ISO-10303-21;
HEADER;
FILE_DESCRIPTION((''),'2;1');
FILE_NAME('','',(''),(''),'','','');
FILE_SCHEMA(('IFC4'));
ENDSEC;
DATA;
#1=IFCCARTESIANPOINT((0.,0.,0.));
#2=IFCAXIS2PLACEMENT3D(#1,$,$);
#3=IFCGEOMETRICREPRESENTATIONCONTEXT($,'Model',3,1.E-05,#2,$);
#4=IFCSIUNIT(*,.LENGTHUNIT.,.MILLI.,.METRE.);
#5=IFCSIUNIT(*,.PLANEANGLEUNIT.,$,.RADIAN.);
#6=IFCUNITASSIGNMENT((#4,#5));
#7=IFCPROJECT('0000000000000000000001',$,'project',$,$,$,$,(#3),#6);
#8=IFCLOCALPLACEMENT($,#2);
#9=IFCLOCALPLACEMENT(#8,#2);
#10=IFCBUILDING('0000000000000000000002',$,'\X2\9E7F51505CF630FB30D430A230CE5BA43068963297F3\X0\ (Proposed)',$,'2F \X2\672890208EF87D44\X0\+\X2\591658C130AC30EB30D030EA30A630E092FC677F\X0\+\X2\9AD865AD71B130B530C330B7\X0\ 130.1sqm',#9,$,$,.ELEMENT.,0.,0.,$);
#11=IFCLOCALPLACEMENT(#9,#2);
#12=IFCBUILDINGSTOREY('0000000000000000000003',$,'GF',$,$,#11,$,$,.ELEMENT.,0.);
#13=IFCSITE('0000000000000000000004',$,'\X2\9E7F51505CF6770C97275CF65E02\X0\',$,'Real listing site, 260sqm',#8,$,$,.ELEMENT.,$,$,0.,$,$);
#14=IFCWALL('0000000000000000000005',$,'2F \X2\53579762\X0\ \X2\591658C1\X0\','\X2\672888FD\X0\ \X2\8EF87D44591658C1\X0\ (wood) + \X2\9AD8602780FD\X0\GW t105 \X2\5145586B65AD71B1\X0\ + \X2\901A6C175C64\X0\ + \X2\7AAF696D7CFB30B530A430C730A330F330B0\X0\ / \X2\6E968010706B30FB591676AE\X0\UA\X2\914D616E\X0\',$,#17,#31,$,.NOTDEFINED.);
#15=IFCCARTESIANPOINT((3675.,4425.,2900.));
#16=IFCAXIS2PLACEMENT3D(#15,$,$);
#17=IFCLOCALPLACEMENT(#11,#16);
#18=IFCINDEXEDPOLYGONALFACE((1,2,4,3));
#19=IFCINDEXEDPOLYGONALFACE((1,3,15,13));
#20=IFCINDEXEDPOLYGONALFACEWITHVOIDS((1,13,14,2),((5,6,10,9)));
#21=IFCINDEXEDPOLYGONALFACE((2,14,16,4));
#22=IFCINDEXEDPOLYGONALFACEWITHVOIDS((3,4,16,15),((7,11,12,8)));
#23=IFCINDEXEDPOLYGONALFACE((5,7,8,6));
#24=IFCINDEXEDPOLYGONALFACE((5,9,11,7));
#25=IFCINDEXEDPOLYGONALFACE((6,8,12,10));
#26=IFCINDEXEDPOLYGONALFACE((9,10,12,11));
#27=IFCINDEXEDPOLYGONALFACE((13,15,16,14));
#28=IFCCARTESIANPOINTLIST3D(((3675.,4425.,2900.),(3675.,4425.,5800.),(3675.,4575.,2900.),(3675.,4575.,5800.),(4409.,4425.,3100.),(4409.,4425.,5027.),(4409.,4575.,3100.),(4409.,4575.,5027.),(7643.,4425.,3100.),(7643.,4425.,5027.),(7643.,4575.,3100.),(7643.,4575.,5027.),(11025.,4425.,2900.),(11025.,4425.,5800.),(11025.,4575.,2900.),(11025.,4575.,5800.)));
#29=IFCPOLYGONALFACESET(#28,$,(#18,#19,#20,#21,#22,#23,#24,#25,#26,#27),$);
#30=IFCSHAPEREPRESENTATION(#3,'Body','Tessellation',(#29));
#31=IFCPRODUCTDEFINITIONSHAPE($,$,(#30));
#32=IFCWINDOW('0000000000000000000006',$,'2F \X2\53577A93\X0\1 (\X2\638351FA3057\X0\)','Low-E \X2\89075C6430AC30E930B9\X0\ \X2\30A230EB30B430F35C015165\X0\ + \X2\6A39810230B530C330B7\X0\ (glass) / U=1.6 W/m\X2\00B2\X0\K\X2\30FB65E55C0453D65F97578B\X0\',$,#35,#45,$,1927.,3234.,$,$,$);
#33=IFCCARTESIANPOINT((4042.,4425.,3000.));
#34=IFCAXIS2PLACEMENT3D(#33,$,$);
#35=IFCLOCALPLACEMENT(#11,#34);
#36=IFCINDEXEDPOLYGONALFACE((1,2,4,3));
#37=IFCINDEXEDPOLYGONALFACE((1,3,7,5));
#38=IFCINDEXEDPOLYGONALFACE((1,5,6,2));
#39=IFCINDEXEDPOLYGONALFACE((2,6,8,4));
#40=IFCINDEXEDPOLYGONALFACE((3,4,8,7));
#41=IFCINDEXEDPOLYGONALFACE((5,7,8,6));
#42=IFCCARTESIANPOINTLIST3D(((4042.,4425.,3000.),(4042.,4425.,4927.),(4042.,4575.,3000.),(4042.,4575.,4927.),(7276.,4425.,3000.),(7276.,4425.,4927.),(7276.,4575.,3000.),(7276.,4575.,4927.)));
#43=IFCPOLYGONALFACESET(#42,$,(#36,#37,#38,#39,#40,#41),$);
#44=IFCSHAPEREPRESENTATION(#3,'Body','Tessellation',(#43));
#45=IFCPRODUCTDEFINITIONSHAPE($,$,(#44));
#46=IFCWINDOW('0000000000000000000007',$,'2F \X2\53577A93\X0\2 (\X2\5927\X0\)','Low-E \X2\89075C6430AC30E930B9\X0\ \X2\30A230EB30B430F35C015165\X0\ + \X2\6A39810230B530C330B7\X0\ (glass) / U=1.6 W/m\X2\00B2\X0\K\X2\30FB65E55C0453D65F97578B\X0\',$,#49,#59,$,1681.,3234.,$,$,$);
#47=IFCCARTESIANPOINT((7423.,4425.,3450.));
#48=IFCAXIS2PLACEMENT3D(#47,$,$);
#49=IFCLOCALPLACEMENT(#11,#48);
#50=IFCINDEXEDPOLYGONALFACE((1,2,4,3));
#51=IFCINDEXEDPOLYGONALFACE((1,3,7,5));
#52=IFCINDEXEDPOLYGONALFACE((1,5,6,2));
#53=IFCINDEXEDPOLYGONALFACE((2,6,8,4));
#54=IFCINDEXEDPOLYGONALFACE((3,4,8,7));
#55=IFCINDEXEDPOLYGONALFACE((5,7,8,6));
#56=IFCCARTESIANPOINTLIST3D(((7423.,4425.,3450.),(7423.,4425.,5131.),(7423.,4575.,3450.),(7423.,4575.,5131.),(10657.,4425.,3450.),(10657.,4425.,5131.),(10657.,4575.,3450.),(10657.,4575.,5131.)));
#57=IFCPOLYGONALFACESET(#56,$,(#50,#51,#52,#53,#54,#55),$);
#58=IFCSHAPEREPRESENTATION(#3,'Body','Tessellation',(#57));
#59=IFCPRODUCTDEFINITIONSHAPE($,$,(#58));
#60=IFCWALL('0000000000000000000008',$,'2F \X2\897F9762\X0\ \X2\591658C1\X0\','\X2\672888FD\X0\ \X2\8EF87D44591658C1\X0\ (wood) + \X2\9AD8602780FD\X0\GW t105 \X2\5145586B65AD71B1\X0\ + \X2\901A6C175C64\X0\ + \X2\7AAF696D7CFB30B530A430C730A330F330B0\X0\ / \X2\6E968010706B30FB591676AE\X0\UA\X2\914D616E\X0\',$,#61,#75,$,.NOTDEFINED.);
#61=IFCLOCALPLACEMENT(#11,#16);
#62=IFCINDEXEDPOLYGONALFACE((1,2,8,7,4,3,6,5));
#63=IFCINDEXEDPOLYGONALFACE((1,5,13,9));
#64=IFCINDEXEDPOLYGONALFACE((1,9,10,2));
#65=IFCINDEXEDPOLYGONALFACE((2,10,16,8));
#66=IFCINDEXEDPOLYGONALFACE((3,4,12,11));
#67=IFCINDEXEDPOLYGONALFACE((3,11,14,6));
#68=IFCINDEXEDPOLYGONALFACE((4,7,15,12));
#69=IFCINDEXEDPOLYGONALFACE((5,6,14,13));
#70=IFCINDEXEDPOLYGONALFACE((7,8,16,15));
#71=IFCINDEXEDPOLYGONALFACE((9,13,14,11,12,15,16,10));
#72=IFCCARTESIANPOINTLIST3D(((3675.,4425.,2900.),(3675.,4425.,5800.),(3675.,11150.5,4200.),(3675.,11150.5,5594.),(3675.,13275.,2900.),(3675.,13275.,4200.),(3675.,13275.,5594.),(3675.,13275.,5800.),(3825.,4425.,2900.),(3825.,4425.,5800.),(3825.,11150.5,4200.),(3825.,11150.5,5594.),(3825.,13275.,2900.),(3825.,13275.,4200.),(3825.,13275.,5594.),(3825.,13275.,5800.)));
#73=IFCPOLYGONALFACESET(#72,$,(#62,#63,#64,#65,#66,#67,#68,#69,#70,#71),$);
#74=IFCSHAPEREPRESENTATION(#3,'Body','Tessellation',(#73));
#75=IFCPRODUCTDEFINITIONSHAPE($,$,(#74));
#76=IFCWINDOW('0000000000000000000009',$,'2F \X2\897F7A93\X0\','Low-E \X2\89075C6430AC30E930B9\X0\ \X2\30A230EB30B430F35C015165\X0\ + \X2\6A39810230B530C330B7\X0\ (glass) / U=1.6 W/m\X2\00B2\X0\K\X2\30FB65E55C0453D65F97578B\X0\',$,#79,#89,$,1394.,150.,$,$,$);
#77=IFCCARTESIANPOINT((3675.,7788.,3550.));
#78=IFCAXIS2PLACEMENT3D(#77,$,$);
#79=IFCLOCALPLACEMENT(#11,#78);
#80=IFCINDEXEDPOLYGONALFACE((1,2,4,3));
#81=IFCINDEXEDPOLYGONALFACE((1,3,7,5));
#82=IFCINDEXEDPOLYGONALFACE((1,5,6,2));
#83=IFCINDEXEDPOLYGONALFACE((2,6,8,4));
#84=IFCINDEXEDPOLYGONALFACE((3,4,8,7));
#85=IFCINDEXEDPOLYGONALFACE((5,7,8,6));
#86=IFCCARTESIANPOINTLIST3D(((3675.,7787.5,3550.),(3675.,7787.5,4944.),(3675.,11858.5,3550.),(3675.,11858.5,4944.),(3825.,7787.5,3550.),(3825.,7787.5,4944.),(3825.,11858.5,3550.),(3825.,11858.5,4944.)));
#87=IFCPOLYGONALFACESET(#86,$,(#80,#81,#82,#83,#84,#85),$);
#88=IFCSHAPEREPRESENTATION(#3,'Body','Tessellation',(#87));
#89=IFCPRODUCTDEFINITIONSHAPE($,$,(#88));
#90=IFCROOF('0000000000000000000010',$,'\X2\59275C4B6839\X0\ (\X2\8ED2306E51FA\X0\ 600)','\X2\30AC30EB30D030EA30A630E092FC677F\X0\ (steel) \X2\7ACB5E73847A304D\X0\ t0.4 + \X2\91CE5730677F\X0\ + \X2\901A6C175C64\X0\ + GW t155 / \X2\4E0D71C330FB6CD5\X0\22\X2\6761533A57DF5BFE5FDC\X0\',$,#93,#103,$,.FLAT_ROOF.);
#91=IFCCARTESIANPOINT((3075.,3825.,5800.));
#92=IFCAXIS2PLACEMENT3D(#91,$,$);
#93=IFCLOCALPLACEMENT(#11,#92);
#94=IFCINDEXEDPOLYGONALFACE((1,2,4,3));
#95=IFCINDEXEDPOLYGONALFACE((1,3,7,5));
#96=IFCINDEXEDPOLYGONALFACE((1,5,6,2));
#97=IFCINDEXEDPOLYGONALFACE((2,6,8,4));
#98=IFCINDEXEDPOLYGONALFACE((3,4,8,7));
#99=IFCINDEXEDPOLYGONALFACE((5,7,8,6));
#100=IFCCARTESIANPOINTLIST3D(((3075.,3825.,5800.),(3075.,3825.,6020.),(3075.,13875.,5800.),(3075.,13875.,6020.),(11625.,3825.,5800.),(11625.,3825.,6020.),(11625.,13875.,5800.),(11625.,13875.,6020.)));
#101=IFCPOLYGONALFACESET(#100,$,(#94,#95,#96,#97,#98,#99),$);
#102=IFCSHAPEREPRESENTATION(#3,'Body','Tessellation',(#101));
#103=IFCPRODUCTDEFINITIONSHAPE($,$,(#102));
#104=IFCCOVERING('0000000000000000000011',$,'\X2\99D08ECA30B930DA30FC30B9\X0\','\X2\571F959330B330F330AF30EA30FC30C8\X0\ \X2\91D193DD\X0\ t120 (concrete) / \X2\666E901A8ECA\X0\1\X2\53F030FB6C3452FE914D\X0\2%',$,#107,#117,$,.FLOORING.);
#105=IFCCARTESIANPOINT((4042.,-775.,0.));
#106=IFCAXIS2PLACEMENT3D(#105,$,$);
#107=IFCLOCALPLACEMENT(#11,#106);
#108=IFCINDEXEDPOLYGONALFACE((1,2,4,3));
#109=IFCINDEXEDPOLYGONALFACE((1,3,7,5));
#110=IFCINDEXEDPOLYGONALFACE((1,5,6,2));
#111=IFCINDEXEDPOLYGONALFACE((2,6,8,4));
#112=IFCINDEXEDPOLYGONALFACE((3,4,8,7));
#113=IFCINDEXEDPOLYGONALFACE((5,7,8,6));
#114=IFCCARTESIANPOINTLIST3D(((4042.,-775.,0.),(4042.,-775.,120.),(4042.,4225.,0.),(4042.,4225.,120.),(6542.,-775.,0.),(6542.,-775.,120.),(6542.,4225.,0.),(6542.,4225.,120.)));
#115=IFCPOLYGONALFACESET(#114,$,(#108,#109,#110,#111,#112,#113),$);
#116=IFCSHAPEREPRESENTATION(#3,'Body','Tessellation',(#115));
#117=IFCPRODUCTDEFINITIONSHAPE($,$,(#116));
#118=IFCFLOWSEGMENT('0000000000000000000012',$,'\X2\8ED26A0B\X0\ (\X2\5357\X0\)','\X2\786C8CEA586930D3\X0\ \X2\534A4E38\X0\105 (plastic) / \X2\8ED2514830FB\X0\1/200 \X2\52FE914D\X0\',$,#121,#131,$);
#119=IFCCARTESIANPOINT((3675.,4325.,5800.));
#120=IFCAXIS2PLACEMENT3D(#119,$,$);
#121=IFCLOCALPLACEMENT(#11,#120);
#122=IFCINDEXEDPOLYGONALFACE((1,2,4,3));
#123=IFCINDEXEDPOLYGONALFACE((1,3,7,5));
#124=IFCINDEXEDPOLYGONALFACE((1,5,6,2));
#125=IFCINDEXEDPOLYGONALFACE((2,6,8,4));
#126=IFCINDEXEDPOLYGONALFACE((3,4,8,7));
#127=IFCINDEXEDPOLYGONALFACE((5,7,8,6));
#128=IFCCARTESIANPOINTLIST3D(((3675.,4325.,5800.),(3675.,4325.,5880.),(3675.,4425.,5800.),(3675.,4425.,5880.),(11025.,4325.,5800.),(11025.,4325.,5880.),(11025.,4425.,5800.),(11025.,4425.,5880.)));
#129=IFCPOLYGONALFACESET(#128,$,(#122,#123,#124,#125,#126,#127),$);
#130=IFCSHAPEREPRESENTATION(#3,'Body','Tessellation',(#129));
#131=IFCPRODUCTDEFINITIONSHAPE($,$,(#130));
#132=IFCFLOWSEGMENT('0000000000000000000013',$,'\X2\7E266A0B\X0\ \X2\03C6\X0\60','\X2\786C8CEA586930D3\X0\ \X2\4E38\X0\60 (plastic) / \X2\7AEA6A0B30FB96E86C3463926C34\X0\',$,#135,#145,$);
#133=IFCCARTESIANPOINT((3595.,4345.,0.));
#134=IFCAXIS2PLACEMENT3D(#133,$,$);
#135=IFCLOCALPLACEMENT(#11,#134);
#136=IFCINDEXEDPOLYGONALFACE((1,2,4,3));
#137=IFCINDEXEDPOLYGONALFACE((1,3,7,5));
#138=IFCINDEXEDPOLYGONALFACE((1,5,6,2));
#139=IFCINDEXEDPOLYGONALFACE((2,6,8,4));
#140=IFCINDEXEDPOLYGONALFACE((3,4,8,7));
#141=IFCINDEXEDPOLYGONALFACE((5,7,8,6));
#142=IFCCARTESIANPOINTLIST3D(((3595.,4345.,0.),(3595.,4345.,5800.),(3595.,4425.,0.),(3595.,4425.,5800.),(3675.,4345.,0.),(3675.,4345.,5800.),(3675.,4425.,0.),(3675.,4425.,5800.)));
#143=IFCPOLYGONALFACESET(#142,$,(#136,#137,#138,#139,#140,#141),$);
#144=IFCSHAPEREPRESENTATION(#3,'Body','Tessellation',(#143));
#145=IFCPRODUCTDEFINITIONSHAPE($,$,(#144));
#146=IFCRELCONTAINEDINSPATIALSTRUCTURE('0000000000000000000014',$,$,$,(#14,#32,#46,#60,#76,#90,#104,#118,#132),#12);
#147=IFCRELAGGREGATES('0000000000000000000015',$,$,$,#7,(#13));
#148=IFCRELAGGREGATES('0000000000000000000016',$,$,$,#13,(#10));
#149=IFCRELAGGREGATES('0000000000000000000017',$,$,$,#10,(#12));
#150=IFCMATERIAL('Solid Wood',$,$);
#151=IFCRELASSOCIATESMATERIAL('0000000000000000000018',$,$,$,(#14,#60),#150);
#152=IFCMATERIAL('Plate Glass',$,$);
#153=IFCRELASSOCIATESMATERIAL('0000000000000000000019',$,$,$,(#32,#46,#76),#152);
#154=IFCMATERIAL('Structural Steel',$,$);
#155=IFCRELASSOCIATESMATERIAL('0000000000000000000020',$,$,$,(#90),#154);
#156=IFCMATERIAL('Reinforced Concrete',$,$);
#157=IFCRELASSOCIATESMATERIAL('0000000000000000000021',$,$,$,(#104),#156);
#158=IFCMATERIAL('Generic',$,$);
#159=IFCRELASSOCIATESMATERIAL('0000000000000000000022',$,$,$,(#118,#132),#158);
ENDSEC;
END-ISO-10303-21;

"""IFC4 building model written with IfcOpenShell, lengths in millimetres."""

from ifc_helpers import new_model, si_unit, frame, frame_2d, origin, place, context, project, spatial, rectangle, extrude, material, element, fill, save


model = new_model("IFC4")

# Units and contexts
model_context = context("Model", 3, precision=1e-05, world=origin())
ifc_project = project(units=[si_unit("LENGTHUNIT", "METRE", prefix="MILLI"), si_unit("PLANEANGLEUNIT", "RADIAN")], contexts=[model_context])

# Site, building, storey
site_placement = place(None, origin())
site = spatial("IfcSite", under=ifc_project, at=site_placement, Name="鹿児島県霧島市", ObjectType="Real listing site, 260sqm", CompositionType="ELEMENT", RefElevation=0.0)
building_placement = place(site_placement, origin())
building = spatial("IfcBuilding", under=site, at=building_placement, Name="鹿児島・ピアノ室と防音 (Proposed)", ObjectType="2F 木造軸組+外壁ガルバリウム鋼板+高断熱サッシ 130.1sqm", CompositionType="ELEMENT", ElevationOfRefHeight=0.0, ElevationOfTerrain=0.0)
storey_placement = place(building_placement, origin())
storey = spatial("IfcBuildingStorey", under=building, at=storey_placement, Name="GF", CompositionType="ELEMENT", Elevation=0.0)

# Shared definitions
ifc_material_1 = material(Name="Solid Wood")

# Shared definitions
ifc_material_2 = material(Name="Reinforced Concrete")

# Shared definitions
ifc_material_3 = material(Name="Plate Glass")

# Wall, openings, windows
wall_1_placement = place(storey_placement, frame((3675.0, 4425.0, 2900.0)))
wall_1 = element("IfcWall", 1, at=wall_1_placement, inside=storey, material=ifc_material_1, Name="2F 南面 外壁", Description="木製 軸組外壁 (wood) + 高性能GW t105 充填断熱 + 通気層 + 窯業系サイディング / 準耐火・外皮UA配慮", PredefinedType="NOTDEFINED", context=model_context, shape_type="SweptSolid", body=[
    extrude(rectangle(XDim=7350.0, YDim=150.0, at=frame_2d((3675.0, 75.0))), frame((3675.0, 4425.0, 2900.0)), (0.0, 0.0, 1.0), 2900.0),
])
opening_1_placement = place(storey_placement, frame((4042.0, 4425.0, 3000.0)))
opening_1 = element("IfcOpeningElement", 2, at=opening_1_placement, cuts=wall_1, PredefinedType="NOTDEFINED", context=model_context, shape_type="SweptSolid", body=[
    extrude(rectangle(XDim=3234.0, YDim=150.0, at=frame_2d((1617.0, 75.0))), frame((4042.0, 4425.0, 3000.0)), (0.0, 0.0, 1.0), 1927.0),
])
opening_2_placement = place(storey_placement, frame((7423.0, 4425.0, 3450.0)))
opening_2 = element("IfcOpeningElement", 3, at=opening_2_placement, cuts=wall_1, PredefinedType="NOTDEFINED", context=model_context, shape_type="SweptSolid", body=[
    extrude(rectangle(XDim=3234.0, YDim=150.0, at=frame_2d((1617.0, 75.0))), frame((7423.0, 4425.0, 3450.0)), (0.0, 0.0, 1.0), 1681.0),
])
window_1_placement = place(storey_placement, frame((4042.0, 4425.0, 3000.0)))
window_1 = element("IfcWindow", 4, at=window_1_placement, inside=storey, material=ifc_material_3, Name="2F 南窓1 (掃出し)", Description="Low-E 複層ガラス アルゴン封入 + 樹脂サッシ (glass) / U=1.6 W/m²K・日射取得型", OverallHeight=1927.0, OverallWidth=3234.0, context=model_context, shape_type="SweptSolid", body=[
    extrude(rectangle(XDim=3234.0, YDim=150.0, at=frame_2d((1617.0, 75.0))), frame((4042.0, 4425.0, 3000.0)), (0.0, 0.0, 1.0), 1927.0),
])
fill(opening_1, window_1)
window_2_placement = place(storey_placement, frame((7423.0, 4425.0, 3450.0)))
window_2 = element("IfcWindow", 5, at=window_2_placement, inside=storey, material=ifc_material_3, Name="2F 南窓2 (大)", Description="Low-E 複層ガラス アルゴン封入 + 樹脂サッシ (glass) / U=1.6 W/m²K・日射取得型", OverallHeight=1681.0, OverallWidth=3234.0, context=model_context, shape_type="SweptSolid", body=[
    extrude(rectangle(XDim=3234.0, YDim=150.0, at=frame_2d((1617.0, 75.0))), frame((7423.0, 4425.0, 3450.0)), (0.0, 0.0, 1.0), 1681.0),
])
fill(opening_2, window_2)

# Wall, opening, window
wall_2_placement = place(storey_placement, frame((3675.0, 4425.0, 2900.0)))
wall_2 = element("IfcWall", 6, at=wall_2_placement, inside=storey, material=ifc_material_1, Name="2F 西面 外壁", Description="木製 軸組外壁 (wood) + 高性能GW t105 充填断熱 + 通気層 + 窯業系サイディング / 準耐火・外皮UA配慮", PredefinedType="NOTDEFINED", context=model_context, shape_type="SweptSolid", body=[
    extrude(rectangle(XDim=150.0, YDim=8850.0, at=frame_2d((75.0, 4425.0))), frame((3675.0, 4425.0, 2900.0)), (0.0, 0.0, 1.0), 2900.0),
])
opening_3_placement = place(storey_placement, frame((3675.0, 7788.0, 3550.0)))
opening_3 = element("IfcOpeningElement", 7, at=opening_3_placement, cuts=wall_2, PredefinedType="NOTDEFINED", context=model_context, shape_type="SweptSolid", body=[
    extrude(rectangle(XDim=150.0, YDim=4071.0, at=frame_2d((75.0, 2035.0))), frame((3675.0, 7788.0, 3550.0)), (0.0, 0.0, 1.0), 1394.0),
])
window_3_placement = place(storey_placement, frame((3675.0, 7788.0, 3550.0)))
window_3 = element("IfcWindow", 8, at=window_3_placement, inside=storey, material=ifc_material_3, Name="2F 西窓", Description="Low-E 複層ガラス アルゴン封入 + 樹脂サッシ (glass) / U=1.6 W/m²K・日射取得型", OverallHeight=1394.0, OverallWidth=150.0, context=model_context, shape_type="SweptSolid", body=[
    extrude(rectangle(XDim=150.0, YDim=4071.0, at=frame_2d((75.0, 2035.0))), frame((3675.0, 7788.0, 3550.0)), (0.0, 0.0, 1.0), 1394.0),
])
fill(opening_3, window_3)

# Roof
ifc_material_4 = material(Name="Structural Steel")
roof_placement = place(storey_placement, frame((3075.0, 3825.0, 5800.0)))
element("IfcRoof", 9, at=roof_placement, inside=storey, material=ifc_material_4, Name="大屋根 (軒の出 600)", Description="ガルバリウム鋼板 (steel) 立平葺き t0.4 + 野地板 + 通気層 + GW t155 / 不燃・法22条区域対応", PredefinedType="FLAT_ROOF", context=model_context, shape_type="SweptSolid", body=[
    extrude(rectangle(XDim=8550.0, YDim=10050.0, at=frame_2d((4275.0, 5025.0))), frame((3075.0, 3825.0, 5800.0)), (0.0, 0.0, 1.0), 220.0),
])

# Covering
covering_placement = place(storey_placement, frame((4042.0, -775.0, 0.0)))
element("IfcCovering", 10, at=covering_placement, inside=storey, material=ifc_material_2, Name="駐車スペース", Description="土間コンクリート 金鏝 t120 (concrete) / 普通車1台・水勾配2%", PredefinedType="FLOORING", context=model_context, shape_type="SweptSolid", body=[
    extrude(rectangle(XDim=2500.0, YDim=5000.0, at=frame_2d((1250.0, 2500.0))), frame((4042.0, -775.0, 0.0)), (0.0, 0.0, 1.0), 120.0),
])

# Flow segments
ifc_material_5 = material(Name="Generic")
flow_segment_1_placement = place(storey_placement, frame((3675.0, 4325.0, 5800.0)))
element("IfcFlowSegment", 11, at=flow_segment_1_placement, inside=storey, material=ifc_material_5, Name="軒樋 (南)", Description="硬質塩ビ 半丸105 (plastic) / 軒先・1/200 勾配", context=model_context, shape_type="SweptSolid", body=[
    extrude(rectangle(XDim=7350.0, YDim=100.0, at=frame_2d((3675.0, 50.0))), frame((3675.0, 4325.0, 5800.0)), (0.0, 0.0, 1.0), 80.0),
])
flow_segment_2_placement = place(storey_placement, frame((3595.0, 4345.0, 0.0)))
element("IfcFlowSegment", 12, at=flow_segment_2_placement, inside=storey, material=ifc_material_5, Name="縦樋 φ60", Description="硬質塩ビ 丸60 (plastic) / 竪樋・雨水排水", context=model_context, shape_type="SweptSolid", body=[
    extrude(rectangle(XDim=80.0, YDim=80.0, at=frame_2d((40.0, 40.0))), frame((3595.0, 4345.0, 0.0)), (0.0, 0.0, 1.0), 5800.0),
])

save(model, "model.ifc")
